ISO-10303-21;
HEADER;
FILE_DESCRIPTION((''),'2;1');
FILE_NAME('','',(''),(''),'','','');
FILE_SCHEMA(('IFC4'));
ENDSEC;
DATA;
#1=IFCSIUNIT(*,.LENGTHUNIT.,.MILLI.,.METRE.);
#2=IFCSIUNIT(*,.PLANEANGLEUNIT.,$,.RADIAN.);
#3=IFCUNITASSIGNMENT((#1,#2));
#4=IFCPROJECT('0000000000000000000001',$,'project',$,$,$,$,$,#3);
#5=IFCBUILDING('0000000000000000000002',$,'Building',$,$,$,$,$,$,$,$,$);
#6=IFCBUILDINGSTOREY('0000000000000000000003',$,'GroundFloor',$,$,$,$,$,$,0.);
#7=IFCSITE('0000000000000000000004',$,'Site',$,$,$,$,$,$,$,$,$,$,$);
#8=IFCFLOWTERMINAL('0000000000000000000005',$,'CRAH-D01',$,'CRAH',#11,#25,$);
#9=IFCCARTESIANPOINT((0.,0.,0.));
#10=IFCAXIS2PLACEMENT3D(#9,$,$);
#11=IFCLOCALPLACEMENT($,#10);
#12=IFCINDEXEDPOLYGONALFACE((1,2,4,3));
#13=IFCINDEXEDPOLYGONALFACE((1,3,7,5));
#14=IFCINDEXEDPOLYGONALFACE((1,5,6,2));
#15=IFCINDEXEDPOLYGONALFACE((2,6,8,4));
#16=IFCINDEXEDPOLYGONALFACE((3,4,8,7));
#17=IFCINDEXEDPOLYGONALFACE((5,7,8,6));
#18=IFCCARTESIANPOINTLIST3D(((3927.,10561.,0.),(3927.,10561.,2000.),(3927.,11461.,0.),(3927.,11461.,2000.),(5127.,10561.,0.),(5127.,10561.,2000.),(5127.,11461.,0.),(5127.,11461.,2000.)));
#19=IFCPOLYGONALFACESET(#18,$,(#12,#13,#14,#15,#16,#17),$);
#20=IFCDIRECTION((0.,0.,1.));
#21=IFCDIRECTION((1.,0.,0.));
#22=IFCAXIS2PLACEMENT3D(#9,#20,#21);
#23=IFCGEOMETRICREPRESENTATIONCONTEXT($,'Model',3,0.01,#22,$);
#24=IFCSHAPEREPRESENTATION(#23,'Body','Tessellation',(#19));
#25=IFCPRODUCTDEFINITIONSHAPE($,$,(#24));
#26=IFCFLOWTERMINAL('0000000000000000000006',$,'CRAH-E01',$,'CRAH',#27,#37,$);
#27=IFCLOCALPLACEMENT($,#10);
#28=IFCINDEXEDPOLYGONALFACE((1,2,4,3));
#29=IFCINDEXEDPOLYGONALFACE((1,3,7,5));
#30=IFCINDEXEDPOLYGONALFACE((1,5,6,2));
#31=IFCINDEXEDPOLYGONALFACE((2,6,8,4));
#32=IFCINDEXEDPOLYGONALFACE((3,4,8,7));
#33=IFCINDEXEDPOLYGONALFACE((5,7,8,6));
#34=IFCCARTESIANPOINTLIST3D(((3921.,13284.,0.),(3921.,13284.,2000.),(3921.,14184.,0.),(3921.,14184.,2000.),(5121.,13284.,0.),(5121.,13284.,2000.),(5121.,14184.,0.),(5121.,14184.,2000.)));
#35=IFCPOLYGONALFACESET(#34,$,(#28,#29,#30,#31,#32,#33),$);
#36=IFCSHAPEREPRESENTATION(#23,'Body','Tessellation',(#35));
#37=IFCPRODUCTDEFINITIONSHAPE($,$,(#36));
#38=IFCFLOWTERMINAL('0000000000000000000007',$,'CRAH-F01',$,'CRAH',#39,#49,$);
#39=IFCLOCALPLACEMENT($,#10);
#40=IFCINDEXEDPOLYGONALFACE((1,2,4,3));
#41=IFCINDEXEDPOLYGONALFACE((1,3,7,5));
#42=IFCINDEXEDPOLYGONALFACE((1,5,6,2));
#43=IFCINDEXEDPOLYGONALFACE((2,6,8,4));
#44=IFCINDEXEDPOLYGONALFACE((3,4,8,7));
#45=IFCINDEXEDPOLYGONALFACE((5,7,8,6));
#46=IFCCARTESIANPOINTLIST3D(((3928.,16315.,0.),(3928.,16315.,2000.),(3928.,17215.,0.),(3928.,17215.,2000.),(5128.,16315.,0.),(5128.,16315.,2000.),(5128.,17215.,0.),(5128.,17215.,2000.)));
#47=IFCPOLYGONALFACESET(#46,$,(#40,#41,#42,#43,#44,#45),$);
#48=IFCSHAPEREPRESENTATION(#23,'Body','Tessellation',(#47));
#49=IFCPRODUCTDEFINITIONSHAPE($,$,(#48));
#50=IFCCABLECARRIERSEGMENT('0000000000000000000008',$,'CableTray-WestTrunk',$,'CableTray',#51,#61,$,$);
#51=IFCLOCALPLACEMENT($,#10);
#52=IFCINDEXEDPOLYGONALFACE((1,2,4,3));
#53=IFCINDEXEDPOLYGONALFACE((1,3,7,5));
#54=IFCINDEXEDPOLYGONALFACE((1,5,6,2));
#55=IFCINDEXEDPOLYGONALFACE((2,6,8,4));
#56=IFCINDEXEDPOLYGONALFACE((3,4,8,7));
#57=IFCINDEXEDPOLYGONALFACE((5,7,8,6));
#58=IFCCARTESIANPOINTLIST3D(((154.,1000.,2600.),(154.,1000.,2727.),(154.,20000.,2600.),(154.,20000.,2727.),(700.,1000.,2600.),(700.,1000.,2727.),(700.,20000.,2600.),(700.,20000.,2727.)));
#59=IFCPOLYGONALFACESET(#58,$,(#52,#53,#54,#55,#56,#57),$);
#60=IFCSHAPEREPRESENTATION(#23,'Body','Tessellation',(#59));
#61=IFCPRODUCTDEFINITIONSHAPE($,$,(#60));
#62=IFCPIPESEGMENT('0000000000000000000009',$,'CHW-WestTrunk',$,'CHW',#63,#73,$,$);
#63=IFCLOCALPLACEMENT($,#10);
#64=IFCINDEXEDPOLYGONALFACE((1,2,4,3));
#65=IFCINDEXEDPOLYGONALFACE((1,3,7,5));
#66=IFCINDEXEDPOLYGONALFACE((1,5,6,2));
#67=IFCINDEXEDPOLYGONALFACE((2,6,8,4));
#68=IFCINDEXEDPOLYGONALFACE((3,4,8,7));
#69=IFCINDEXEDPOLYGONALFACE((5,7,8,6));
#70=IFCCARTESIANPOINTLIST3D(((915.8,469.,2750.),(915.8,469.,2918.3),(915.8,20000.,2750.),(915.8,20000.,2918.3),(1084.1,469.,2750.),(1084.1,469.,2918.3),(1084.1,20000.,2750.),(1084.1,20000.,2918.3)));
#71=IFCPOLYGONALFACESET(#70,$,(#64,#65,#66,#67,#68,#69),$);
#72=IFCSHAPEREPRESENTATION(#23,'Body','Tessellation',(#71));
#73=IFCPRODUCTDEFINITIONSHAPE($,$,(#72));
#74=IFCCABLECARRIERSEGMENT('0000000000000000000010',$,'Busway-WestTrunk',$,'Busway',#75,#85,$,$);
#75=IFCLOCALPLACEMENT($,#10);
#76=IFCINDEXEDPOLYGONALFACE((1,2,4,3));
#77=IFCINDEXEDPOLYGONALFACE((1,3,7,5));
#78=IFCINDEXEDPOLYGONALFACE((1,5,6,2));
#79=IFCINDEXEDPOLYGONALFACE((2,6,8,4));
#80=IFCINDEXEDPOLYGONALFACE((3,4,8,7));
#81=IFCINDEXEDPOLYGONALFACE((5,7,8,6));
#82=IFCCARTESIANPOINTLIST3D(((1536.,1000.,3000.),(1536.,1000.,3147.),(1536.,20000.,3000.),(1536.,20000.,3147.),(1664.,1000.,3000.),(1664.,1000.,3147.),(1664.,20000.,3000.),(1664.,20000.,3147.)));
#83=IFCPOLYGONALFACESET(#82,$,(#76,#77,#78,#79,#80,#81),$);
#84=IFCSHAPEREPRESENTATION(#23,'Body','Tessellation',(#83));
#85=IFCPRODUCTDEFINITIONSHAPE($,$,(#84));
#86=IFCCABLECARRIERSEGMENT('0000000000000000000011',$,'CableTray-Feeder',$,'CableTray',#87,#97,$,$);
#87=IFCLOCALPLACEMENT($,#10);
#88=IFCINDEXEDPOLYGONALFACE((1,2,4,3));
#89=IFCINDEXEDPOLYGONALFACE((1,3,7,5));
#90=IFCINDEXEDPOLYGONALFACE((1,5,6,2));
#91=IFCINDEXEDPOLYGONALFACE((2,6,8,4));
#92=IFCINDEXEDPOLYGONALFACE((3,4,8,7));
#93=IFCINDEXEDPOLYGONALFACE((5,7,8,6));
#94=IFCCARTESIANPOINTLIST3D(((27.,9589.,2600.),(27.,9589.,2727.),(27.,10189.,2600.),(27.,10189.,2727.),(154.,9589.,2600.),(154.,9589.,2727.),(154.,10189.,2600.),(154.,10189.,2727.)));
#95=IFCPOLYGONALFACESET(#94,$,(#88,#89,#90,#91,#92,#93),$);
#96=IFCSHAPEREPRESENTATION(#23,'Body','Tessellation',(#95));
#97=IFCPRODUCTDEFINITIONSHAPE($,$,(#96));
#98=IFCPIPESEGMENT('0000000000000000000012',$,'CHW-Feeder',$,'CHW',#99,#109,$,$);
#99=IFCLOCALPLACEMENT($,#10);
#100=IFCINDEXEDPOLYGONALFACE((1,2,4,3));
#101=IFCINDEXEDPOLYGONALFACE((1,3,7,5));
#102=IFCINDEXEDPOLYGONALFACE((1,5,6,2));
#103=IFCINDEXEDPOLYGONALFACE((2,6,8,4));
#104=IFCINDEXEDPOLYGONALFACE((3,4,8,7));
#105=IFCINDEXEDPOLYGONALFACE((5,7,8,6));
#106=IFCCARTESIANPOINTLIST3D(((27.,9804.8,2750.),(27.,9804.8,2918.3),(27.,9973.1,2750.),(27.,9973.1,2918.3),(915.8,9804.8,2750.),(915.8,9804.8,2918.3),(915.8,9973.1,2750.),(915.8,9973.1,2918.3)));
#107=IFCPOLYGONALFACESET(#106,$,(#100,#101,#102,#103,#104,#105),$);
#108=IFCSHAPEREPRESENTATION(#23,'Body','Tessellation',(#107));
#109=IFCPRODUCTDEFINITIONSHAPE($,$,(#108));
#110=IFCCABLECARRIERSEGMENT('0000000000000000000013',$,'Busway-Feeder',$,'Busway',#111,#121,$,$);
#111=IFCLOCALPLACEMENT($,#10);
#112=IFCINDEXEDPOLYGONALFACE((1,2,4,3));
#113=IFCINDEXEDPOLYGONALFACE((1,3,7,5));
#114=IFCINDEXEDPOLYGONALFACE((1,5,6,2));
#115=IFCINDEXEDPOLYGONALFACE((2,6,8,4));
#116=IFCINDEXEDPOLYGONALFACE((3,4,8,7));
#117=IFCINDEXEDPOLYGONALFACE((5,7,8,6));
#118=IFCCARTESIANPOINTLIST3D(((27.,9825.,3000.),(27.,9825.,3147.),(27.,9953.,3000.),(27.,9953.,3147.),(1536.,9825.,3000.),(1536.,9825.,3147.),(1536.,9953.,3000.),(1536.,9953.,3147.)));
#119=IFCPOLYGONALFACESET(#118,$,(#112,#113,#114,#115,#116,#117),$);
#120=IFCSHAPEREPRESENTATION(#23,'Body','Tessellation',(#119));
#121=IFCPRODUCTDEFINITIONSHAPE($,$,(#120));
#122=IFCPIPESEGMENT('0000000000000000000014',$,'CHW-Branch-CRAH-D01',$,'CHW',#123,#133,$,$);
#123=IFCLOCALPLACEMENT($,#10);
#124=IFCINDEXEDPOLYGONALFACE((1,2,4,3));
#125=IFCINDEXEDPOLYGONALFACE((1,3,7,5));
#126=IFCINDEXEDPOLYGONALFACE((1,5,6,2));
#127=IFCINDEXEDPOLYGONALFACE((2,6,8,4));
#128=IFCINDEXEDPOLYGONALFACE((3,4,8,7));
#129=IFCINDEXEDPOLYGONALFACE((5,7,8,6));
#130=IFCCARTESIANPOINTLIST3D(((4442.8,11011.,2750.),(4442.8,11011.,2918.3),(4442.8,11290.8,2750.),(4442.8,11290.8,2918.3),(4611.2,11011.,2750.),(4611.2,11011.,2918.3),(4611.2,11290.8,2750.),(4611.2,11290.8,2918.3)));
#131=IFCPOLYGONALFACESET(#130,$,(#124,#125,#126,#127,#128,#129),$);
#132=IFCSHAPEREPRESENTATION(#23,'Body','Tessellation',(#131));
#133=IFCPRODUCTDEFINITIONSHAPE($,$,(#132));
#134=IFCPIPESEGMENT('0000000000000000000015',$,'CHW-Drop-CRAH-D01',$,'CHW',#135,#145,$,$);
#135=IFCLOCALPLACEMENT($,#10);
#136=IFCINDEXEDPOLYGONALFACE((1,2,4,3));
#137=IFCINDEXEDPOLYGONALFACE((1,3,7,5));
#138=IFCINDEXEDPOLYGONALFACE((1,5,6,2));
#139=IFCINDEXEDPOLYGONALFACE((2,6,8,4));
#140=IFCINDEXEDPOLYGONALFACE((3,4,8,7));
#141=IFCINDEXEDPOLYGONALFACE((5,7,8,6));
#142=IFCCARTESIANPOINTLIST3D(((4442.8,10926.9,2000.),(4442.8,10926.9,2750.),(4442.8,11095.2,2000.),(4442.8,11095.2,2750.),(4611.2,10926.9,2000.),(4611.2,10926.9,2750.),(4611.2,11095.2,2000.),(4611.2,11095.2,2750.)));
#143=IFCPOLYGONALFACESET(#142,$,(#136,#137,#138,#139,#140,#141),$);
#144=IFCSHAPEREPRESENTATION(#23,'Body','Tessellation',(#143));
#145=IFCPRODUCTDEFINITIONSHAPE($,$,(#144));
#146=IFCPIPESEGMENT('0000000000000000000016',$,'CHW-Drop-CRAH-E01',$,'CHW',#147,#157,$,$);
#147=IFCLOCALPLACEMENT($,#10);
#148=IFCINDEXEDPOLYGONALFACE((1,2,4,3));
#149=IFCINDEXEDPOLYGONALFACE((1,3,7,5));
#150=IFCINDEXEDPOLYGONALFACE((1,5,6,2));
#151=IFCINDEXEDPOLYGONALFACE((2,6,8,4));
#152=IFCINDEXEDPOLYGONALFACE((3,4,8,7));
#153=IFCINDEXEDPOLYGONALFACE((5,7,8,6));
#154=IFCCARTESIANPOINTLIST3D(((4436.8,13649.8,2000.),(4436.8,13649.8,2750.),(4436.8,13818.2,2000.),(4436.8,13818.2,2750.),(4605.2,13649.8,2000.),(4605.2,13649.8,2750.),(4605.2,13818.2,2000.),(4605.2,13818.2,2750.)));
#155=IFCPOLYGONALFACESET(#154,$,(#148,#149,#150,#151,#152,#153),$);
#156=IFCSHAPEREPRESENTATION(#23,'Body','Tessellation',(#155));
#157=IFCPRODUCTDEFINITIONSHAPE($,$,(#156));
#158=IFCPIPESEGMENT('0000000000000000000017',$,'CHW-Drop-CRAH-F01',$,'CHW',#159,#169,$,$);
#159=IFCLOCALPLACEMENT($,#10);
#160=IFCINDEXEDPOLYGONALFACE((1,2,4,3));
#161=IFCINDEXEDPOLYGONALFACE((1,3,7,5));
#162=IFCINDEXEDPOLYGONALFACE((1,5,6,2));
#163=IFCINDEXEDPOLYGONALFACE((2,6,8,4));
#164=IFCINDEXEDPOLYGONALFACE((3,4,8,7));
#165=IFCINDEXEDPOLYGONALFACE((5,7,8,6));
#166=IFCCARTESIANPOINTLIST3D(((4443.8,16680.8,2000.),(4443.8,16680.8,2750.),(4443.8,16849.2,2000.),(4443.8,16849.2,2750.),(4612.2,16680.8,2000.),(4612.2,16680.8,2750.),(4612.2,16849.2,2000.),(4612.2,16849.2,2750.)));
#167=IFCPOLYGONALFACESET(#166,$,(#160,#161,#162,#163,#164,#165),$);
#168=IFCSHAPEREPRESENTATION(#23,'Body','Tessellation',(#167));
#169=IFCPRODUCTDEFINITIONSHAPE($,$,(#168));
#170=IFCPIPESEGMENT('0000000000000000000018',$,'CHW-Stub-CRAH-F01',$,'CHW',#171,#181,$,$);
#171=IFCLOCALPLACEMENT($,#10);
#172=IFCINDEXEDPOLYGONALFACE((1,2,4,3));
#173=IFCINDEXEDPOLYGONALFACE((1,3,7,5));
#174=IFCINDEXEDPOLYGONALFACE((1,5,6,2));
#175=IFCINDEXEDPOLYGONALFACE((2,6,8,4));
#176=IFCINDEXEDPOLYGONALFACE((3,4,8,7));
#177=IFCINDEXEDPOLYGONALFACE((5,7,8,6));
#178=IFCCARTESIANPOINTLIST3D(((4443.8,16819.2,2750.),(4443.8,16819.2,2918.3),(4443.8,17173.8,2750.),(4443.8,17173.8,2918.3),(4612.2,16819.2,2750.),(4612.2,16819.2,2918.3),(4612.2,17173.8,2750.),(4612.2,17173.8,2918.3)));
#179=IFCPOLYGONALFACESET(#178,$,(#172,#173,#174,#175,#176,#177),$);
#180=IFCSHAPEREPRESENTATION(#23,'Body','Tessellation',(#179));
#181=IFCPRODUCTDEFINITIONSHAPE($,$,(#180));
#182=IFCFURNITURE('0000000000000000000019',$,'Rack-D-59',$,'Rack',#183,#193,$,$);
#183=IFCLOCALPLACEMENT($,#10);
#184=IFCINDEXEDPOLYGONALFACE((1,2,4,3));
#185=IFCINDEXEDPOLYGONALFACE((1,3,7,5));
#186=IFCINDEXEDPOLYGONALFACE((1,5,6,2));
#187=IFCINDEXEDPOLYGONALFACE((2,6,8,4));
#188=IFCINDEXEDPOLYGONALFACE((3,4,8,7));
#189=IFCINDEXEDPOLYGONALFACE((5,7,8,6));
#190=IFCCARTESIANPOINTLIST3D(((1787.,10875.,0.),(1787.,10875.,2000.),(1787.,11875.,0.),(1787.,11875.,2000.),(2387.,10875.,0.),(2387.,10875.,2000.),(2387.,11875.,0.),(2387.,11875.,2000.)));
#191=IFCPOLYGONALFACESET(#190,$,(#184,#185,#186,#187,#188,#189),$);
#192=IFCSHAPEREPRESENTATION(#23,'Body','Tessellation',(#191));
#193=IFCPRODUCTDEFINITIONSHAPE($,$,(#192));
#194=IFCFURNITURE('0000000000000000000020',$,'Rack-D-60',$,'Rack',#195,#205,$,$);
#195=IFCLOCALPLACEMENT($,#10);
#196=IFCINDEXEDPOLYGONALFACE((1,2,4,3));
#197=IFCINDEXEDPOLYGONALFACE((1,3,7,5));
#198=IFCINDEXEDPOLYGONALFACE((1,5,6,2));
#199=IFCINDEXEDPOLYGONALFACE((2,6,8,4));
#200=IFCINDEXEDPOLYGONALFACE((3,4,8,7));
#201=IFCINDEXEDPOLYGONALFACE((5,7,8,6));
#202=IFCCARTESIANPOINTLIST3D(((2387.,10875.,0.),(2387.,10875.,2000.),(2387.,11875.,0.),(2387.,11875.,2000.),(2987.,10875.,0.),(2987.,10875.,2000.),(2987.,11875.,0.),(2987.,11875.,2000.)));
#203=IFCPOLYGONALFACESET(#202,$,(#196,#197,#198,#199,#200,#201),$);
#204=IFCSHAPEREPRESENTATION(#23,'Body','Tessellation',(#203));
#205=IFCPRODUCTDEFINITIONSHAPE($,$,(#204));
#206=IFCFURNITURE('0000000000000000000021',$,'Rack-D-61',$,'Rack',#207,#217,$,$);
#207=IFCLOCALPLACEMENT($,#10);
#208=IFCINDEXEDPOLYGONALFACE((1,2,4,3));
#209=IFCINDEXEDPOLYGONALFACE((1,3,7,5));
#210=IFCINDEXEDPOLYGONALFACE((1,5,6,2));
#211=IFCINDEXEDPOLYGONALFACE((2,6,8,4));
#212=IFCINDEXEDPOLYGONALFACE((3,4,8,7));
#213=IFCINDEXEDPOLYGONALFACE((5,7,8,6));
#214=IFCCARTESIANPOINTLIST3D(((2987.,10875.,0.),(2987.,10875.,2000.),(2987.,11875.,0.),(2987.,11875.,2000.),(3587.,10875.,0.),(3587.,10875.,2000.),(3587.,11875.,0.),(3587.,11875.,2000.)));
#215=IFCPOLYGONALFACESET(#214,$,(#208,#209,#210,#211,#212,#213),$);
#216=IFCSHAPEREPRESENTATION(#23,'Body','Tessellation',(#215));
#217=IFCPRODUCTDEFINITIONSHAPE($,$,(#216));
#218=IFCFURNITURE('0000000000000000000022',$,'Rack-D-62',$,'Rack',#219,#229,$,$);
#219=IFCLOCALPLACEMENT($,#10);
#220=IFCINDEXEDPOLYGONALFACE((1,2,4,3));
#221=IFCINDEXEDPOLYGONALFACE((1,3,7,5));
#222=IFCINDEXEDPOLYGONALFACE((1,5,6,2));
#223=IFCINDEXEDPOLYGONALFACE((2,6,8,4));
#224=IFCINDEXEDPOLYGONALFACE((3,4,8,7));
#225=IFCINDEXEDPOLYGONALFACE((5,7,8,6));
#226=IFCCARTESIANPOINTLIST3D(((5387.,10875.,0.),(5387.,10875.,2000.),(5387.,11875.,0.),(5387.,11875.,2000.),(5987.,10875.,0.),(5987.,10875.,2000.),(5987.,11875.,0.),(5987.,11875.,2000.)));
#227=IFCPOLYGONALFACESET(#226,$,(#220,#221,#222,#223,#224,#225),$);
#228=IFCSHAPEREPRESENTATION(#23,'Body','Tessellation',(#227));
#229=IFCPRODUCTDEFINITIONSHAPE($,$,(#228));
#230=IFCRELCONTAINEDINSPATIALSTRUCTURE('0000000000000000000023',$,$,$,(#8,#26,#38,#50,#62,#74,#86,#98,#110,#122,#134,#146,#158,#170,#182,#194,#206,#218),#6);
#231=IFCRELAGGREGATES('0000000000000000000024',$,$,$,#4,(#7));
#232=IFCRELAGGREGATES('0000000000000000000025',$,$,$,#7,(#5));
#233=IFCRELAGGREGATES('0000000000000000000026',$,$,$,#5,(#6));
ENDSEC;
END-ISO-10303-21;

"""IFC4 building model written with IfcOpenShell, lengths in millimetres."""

from ifc_helpers import new_model, si_unit, frame, origin, origin_with_axes, origin_2d, place, context, project, spatial, rectangle, extrude, element, save


model = new_model("IFC4")

# Units and contexts
model_context = context("Model", 3, precision=0.01, world=origin_with_axes())
ifc_project = project(units=[si_unit("LENGTHUNIT", "METRE", prefix="MILLI"), si_unit("PLANEANGLEUNIT", "RADIAN")])

# Site, building, storey
site = spatial("IfcSite", under=ifc_project, Name="Site")
building = spatial("IfcBuilding", under=site, Name="Building")
storey = spatial("IfcBuildingStorey", under=building, Name="GroundFloor", Elevation=0.0)

# Flow terminals
for number, where, z_axis, x_axis, name in (
    (1, (4527.0, 11011.0, 0.0), (0.0, 0.0, 1.0), (1.0, 0.0, 0.0), "CRAH-D01"),
    (2, (4521.0, 13734.0, 0.0), (0.0, 0.0, 1.0), (1.0, 0.0, 0.0), "CRAH-E01"),
    (3, (4528.0, 16765.0, 0.0), (0.0, 0.0, 1.0), (1.0, 0.0, 0.0), "CRAH-F01"),
):
    element("IfcFlowTerminal", number, at=place(None, frame(where, z_axis=z_axis, x_axis=x_axis)), inside=storey, Name=name, ObjectType="CRAH", context=model_context, shape_type="SweptSolid", body=[
        extrude(rectangle(XDim=1200.0, YDim=900.0, at=origin_2d()), origin(), (0.0, 0.0, 1.0), 2000.0),
    ])

# Cable carrier segment
cable_carrier_segment_1_placement = place(None, frame((427.0, 10500.0, 2600.0), z_axis=(0.0, 0.0, 1.0), x_axis=(1.0, 0.0, 0.0)))
element("IfcCableCarrierSegment", 4, at=cable_carrier_segment_1_placement, inside=storey, Name="CableTray-WestTrunk", ObjectType="CableTray", context=model_context, shape_type="SweptSolid", body=[
    extrude(rectangle(XDim=546.0, YDim=19000.0, at=origin_2d()), origin(), (0.0, 0.0, 1.0), 127.0),
])

# Pipe segment
pipe_segment_1_placement = place(None, frame((1000.0, 10234.5, 2750.0), z_axis=(0.0, 0.0, 1.0), x_axis=(1.0, 0.0, 0.0)))
element("IfcPipeSegment", 5, at=pipe_segment_1_placement, inside=storey, Name="CHW-WestTrunk", ObjectType="CHW", context=model_context, shape_type="SweptSolid", body=[
    extrude(rectangle(XDim=168.3, YDim=19531.0, at=origin_2d()), origin(), (0.0, 0.0, 1.0), 168.3),
])

# Cable carrier segments
cable_carrier_segment_2_placement = place(None, frame((1600.0, 10500.0, 3000.0), z_axis=(0.0, 0.0, 1.0), x_axis=(1.0, 0.0, 0.0)))
element("IfcCableCarrierSegment", 6, at=cable_carrier_segment_2_placement, inside=storey, Name="Busway-WestTrunk", ObjectType="Busway", context=model_context, shape_type="SweptSolid", body=[
    extrude(rectangle(XDim=128.0, YDim=19000.0, at=origin_2d()), origin(), (0.0, 0.0, 1.0), 147.0),
])
cable_carrier_segment_3_placement = place(None, frame((90.5, 9889.0, 2600.0), z_axis=(0.0, 0.0, 1.0), x_axis=(1.0, 0.0, 0.0)))
element("IfcCableCarrierSegment", 7, at=cable_carrier_segment_3_placement, inside=storey, Name="CableTray-Feeder", ObjectType="CableTray", context=model_context, shape_type="SweptSolid", body=[
    extrude(rectangle(XDim=127.0, YDim=600.0, at=origin_2d()), origin(), (0.0, 0.0, 1.0), 127.0),
])

# Pipe segment
pipe_segment_2_placement = place(None, frame((471.4, 9889.0, 2750.0), z_axis=(0.0, 0.0, 1.0), x_axis=(1.0, 0.0, 0.0)))
element("IfcPipeSegment", 8, at=pipe_segment_2_placement, inside=storey, Name="CHW-Feeder", ObjectType="CHW", context=model_context, shape_type="SweptSolid", body=[
    extrude(rectangle(XDim=888.9, YDim=168.3, at=origin_2d()), origin(), (0.0, 0.0, 1.0), 168.3),
])

# Cable carrier segment
cable_carrier_segment_4_placement = place(None, frame((781.5, 9889.0, 3000.0), z_axis=(0.0, 0.0, 1.0), x_axis=(1.0, 0.0, 0.0)))
element("IfcCableCarrierSegment", 9, at=cable_carrier_segment_4_placement, inside=storey, Name="Busway-Feeder", ObjectType="Busway", context=model_context, shape_type="SweptSolid", body=[
    extrude(rectangle(XDim=1509.0, YDim=128.0, at=origin_2d()), origin(), (0.0, 0.0, 1.0), 147.0),
])

# Pipe segments
pipe_segment_3_placement = place(None, frame((4527.0, 11150.9, 2750.0), z_axis=(0.0, 0.0, 1.0), x_axis=(1.0, 0.0, 0.0)))
element("IfcPipeSegment", 10, at=pipe_segment_3_placement, inside=storey, Name="CHW-Branch-CRAH-D01", ObjectType="CHW", context=model_context, shape_type="SweptSolid", body=[
    extrude(rectangle(XDim=168.3, YDim=279.9, at=origin_2d()), origin(), (0.0, 0.0, 1.0), 168.3),
])
for number, where, z_axis, x_axis, name in (
    (11, (4527.0, 11011.0, 2000.0), (0.0, 0.0, 1.0), (1.0, 0.0, 0.0), "CHW-Drop-CRAH-D01"),
    (12, (4521.0, 13734.0, 2000.0), (0.0, 0.0, 1.0), (1.0, 0.0, 0.0), "CHW-Drop-CRAH-E01"),
    (13, (4528.0, 16765.0, 2000.0), (0.0, 0.0, 1.0), (1.0, 0.0, 0.0), "CHW-Drop-CRAH-F01"),
):
    element("IfcPipeSegment", number, at=place(None, frame(where, z_axis=z_axis, x_axis=x_axis)), inside=storey, Name=name, ObjectType="CHW", context=model_context, shape_type="SweptSolid", body=[
        extrude(rectangle(XDim=168.3, YDim=168.3, at=origin_2d()), origin(), (0.0, 0.0, 1.0), 750.0),
    ])
pipe_segment_4_placement = place(None, frame((4528.0, 16996.5, 2750.0), z_axis=(0.0, 0.0, 1.0), x_axis=(1.0, 0.0, 0.0)))
element("IfcPipeSegment", 14, at=pipe_segment_4_placement, inside=storey, Name="CHW-Stub-CRAH-F01", ObjectType="CHW", context=model_context, shape_type="SweptSolid", body=[
    extrude(rectangle(XDim=168.3, YDim=354.7, at=origin_2d()), origin(), (0.0, 0.0, 1.0), 168.3),
])

# Furniture
for number, where, z_axis, x_axis, name in (
    (15, (2087.0, 11375.0, 0.0), (0.0, 0.0, 1.0), (1.0, 0.0, 0.0), "Rack-D-59"),
    (16, (2687.0, 11375.0, 0.0), (0.0, 0.0, 1.0), (1.0, 0.0, 0.0), "Rack-D-60"),
    (17, (3287.0, 11375.0, 0.0), (0.0, 0.0, 1.0), (1.0, 0.0, 0.0), "Rack-D-61"),
    (18, (5687.0, 11375.0, 0.0), (0.0, 0.0, 1.0), (1.0, 0.0, 0.0), "Rack-D-62"),
):
    element("IfcFurniture", number, at=place(None, frame(where, z_axis=z_axis, x_axis=x_axis)), inside=storey, Name=name, ObjectType="Rack", context=model_context, shape_type="SweptSolid", body=[
        extrude(rectangle(XDim=600.0, YDim=1000.0, at=origin_2d()), origin(), (0.0, 0.0, 1.0), 2000.0),
    ])

save(model, "model.ifc")
